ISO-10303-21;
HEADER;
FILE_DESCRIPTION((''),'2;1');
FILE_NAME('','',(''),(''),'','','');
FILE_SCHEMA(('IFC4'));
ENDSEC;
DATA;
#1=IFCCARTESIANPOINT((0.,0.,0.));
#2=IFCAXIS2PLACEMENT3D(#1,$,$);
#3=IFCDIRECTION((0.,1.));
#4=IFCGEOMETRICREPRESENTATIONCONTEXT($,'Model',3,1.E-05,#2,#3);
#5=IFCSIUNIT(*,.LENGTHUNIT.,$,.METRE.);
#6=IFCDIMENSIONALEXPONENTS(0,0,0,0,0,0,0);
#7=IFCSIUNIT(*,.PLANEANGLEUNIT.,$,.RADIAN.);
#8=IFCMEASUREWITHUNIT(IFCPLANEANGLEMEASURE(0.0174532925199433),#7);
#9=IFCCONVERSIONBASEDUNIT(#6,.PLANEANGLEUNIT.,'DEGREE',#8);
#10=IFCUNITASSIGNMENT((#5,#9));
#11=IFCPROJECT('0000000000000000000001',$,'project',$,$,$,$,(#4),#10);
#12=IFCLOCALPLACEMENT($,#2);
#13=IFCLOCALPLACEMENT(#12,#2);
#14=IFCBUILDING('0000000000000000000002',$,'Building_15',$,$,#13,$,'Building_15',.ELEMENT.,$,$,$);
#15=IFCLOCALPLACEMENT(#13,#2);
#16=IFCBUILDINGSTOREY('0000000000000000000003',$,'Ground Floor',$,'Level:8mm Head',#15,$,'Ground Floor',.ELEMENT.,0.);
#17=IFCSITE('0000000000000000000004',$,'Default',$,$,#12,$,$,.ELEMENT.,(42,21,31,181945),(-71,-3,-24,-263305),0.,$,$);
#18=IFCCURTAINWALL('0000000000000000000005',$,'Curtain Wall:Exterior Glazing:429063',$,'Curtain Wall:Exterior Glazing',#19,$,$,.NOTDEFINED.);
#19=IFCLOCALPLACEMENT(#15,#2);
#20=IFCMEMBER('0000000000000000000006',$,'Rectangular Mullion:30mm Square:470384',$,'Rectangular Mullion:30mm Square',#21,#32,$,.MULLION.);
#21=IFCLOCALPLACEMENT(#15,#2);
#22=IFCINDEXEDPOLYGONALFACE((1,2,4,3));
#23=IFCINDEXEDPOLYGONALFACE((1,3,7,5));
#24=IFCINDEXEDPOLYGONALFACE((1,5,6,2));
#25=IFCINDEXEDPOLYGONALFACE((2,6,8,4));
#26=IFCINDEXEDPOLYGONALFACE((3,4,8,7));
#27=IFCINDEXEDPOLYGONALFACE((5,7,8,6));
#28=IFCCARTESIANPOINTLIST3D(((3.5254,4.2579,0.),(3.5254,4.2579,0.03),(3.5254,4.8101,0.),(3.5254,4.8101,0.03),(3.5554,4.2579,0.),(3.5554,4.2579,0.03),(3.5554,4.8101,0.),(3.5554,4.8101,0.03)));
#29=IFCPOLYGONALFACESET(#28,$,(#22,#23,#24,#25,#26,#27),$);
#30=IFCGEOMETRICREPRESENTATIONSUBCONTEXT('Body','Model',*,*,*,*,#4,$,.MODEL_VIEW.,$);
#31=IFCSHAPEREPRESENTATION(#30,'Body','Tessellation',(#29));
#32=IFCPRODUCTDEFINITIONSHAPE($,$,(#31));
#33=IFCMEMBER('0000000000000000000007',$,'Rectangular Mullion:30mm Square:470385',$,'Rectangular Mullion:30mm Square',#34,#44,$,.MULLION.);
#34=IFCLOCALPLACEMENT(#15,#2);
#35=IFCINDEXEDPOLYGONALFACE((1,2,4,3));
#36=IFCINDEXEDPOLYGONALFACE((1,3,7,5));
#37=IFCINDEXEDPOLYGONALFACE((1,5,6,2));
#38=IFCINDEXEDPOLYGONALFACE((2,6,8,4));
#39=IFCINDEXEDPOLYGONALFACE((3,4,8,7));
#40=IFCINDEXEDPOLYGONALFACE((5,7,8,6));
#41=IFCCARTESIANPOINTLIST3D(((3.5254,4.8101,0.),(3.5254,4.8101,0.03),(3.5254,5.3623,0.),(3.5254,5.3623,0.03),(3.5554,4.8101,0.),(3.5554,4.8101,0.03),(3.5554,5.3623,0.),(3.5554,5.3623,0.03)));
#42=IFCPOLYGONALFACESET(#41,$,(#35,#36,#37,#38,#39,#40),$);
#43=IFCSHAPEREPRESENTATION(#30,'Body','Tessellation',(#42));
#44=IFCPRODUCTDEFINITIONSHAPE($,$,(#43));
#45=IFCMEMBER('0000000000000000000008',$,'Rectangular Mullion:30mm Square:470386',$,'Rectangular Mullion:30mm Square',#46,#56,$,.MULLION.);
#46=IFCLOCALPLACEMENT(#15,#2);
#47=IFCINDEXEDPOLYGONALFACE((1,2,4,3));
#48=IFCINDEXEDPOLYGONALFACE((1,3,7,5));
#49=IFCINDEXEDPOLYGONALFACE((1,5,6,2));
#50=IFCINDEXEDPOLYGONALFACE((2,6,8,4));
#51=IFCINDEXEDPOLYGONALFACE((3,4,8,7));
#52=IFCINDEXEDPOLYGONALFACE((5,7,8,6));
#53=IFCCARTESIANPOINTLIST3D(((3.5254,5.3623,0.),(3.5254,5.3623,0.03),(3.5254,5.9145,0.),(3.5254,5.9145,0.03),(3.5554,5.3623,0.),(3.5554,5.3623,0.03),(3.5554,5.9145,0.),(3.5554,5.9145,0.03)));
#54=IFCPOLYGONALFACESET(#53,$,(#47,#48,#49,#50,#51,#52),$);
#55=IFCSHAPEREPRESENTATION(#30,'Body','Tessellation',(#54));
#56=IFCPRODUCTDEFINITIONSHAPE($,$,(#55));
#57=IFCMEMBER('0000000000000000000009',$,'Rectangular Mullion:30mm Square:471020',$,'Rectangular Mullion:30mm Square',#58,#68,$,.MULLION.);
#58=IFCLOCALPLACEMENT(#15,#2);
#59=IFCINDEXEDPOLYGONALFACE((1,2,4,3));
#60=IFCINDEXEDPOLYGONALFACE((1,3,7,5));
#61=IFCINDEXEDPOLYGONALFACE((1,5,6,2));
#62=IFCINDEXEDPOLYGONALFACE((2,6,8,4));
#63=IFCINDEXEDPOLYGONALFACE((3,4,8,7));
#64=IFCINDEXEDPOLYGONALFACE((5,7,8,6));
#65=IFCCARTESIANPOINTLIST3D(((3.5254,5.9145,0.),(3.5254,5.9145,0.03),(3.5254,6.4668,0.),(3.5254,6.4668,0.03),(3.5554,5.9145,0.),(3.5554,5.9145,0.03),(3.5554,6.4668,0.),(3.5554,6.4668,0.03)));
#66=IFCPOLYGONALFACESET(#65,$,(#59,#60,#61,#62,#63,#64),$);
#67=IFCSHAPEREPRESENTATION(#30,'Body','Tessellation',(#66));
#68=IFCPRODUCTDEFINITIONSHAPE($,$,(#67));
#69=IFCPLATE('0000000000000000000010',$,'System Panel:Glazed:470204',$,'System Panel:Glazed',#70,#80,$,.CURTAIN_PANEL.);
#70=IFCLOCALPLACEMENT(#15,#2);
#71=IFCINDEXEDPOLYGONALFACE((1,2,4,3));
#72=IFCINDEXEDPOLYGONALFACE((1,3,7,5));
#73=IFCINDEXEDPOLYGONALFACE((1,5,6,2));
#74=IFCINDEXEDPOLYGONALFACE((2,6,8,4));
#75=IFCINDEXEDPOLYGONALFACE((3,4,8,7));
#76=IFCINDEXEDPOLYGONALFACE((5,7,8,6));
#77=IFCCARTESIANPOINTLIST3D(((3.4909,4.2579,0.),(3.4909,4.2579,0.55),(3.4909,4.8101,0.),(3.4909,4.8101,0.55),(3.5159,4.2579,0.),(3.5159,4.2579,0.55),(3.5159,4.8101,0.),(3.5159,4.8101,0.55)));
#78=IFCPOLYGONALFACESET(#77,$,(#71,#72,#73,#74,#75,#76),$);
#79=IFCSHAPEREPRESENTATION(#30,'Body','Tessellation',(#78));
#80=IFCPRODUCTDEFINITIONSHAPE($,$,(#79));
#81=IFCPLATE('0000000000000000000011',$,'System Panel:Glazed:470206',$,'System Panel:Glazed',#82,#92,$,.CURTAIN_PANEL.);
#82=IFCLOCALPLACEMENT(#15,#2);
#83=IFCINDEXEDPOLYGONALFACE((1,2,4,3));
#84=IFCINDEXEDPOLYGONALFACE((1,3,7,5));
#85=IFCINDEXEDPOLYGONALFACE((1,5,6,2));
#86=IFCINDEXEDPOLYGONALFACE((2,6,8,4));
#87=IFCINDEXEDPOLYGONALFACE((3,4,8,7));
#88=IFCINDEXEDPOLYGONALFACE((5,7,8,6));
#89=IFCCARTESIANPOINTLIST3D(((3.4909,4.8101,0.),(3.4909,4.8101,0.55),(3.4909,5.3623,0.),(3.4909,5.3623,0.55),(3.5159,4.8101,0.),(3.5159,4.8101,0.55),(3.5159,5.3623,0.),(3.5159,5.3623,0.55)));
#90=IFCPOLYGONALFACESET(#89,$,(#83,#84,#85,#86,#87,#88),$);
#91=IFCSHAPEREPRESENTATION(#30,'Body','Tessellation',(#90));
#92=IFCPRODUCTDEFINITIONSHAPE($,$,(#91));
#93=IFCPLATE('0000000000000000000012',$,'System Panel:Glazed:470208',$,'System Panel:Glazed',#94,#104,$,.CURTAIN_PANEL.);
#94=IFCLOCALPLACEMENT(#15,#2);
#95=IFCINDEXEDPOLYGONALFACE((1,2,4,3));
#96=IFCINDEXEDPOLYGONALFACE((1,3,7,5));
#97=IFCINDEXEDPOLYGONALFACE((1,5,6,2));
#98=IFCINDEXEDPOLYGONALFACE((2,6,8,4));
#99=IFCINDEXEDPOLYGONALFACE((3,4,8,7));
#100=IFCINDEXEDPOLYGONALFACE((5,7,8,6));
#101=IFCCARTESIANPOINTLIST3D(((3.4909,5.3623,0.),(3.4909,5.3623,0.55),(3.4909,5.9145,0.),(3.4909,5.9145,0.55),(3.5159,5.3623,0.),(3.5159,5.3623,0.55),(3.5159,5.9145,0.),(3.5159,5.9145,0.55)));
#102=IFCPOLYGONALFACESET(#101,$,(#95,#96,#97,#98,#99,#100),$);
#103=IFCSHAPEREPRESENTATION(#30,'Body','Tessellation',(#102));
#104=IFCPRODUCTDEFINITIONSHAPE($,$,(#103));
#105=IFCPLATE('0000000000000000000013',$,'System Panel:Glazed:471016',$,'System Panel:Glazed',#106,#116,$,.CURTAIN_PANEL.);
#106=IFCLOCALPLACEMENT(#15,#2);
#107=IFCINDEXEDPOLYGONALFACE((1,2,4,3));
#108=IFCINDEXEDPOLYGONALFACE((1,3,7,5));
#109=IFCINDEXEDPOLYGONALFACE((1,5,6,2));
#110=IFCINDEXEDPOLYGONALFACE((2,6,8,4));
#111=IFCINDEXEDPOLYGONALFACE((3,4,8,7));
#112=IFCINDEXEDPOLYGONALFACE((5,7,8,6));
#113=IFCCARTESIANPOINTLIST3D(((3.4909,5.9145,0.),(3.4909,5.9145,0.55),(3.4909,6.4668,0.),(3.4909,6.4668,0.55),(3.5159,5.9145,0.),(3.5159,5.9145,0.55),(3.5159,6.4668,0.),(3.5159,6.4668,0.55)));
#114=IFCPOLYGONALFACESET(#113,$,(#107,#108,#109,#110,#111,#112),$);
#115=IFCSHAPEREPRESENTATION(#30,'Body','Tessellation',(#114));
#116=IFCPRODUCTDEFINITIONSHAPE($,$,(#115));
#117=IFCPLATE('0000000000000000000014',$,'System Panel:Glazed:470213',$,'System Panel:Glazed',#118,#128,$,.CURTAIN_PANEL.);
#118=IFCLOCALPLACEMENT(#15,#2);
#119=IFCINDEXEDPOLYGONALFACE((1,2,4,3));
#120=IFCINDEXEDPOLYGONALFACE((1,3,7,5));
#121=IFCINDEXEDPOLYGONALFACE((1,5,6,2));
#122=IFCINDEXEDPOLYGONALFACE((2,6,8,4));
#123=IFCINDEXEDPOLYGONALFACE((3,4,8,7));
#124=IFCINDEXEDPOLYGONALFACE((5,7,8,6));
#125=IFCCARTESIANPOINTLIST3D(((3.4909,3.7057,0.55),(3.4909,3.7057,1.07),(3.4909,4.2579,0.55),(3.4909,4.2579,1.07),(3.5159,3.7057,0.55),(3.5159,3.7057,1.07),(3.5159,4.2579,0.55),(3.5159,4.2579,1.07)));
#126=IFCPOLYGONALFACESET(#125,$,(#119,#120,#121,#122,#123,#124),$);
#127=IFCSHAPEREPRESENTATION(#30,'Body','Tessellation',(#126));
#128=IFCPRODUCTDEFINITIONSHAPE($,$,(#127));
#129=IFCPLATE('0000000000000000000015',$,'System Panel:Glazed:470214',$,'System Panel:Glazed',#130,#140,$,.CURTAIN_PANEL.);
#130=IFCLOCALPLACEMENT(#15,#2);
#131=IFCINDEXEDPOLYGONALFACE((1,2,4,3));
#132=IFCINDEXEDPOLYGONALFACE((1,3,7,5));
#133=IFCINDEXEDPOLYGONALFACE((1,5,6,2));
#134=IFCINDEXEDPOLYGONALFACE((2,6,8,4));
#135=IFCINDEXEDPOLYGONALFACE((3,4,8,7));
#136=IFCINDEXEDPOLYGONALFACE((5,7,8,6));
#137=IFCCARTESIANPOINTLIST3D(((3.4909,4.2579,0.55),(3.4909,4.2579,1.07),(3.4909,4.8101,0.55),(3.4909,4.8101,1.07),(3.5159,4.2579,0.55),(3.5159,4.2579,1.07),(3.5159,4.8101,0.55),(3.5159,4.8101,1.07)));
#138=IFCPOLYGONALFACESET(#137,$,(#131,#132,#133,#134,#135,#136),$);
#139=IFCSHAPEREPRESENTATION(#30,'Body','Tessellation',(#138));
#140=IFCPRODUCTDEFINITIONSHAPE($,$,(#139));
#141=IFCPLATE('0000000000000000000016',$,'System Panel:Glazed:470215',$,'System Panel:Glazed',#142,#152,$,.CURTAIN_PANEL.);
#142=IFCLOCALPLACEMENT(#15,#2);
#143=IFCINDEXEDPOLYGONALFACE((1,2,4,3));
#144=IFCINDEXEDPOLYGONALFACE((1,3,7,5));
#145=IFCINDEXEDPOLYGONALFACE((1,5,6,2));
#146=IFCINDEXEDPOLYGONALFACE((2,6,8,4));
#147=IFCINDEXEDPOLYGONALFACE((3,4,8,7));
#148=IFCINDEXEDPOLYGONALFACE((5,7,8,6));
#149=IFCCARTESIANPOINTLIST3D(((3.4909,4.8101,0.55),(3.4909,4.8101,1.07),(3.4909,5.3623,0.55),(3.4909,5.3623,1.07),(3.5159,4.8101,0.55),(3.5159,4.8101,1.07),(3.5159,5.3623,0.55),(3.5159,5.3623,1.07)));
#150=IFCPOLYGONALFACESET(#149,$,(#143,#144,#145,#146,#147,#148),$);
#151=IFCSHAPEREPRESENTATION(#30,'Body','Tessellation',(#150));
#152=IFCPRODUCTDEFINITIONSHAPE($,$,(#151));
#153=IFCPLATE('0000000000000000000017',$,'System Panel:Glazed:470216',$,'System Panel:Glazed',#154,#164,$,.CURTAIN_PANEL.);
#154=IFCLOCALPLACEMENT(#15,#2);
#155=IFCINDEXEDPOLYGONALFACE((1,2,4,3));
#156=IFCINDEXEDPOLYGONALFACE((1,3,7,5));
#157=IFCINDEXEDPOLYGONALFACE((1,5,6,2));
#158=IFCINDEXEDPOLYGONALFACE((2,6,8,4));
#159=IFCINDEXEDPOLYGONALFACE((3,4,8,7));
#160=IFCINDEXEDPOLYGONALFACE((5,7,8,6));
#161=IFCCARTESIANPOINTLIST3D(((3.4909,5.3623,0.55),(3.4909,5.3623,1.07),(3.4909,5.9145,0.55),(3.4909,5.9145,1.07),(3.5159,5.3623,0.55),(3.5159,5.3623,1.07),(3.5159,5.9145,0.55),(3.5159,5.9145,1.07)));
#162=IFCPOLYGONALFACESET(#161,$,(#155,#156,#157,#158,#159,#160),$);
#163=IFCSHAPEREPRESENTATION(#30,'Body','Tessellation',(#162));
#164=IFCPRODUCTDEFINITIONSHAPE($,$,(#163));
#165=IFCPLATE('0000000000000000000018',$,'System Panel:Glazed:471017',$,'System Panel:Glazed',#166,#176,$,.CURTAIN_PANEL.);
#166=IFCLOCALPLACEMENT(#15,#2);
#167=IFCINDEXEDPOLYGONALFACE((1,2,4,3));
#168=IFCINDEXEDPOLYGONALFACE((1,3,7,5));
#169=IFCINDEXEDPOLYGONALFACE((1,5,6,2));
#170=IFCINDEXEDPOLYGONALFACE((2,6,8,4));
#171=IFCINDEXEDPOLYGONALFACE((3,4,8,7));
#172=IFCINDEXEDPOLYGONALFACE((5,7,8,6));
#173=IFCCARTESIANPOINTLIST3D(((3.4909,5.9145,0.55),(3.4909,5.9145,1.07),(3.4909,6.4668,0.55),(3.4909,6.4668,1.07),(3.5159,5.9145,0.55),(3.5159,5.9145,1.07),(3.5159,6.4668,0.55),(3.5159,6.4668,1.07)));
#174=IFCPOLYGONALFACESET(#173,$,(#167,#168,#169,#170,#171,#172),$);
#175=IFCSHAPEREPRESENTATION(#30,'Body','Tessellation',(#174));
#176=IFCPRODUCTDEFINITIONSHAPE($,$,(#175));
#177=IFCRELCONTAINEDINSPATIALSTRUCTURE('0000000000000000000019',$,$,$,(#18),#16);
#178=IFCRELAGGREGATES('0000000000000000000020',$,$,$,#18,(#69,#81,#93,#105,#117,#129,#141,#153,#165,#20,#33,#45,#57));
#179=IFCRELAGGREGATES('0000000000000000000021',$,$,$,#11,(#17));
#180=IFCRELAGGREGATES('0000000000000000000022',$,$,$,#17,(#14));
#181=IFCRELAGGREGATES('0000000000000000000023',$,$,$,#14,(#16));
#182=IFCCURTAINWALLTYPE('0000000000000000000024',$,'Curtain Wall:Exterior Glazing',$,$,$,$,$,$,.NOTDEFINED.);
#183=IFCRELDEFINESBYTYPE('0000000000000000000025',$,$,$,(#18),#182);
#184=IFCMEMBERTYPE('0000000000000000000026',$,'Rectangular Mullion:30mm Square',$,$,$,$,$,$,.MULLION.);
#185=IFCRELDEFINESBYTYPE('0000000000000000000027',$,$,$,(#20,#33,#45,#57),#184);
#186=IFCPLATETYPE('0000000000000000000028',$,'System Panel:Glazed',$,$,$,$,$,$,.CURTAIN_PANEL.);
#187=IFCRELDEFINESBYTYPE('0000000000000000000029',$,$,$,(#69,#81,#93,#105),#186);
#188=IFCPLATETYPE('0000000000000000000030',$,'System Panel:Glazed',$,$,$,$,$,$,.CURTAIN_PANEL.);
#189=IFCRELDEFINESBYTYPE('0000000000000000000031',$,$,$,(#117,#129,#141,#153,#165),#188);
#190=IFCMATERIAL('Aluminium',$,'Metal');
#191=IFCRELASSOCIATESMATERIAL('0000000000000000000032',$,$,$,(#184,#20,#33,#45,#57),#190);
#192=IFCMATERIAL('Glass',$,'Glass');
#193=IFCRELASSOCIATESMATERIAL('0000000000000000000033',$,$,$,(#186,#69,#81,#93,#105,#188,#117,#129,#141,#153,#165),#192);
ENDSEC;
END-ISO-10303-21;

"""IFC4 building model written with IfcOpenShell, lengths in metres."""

from ifc_helpers import new_model, entity, si_unit, converted_unit, direction, frame, origin, place, context, subcontext, project, spatial, indexed_curve, outline, extrude, source, transform, mapped, material, type_object, type_shapes, element, aggregate, save


model = new_model("IFC4")

# Units and contexts
model_context = context("Model", 3, precision=1e-05, world=origin(), true_north=direction((0.0, 1.0)))
body_context = subcontext(model_context, "Body", "Model", "MODEL_VIEW")
ifc_project = project(units=[si_unit("LENGTHUNIT", "METRE"), converted_unit("PLANEANGLEUNIT", "DEGREE", entity("IfcPlaneAngleMeasure", 0.0174532925199433), si_unit("PLANEANGLEUNIT", "RADIAN"), dimensions=[0, 0, 0, 0, 0, 0, 0])], contexts=[model_context])

# Site, building, storey
site_placement = place(None, origin())
site = spatial("IfcSite", under=ifc_project, at=site_placement, Name="Default", CompositionType="ELEMENT", RefLatitude=(42, 21, 31, 181945), RefLongitude=(-71, -3, -24, -263305), RefElevation=0.0)
building_placement = place(site_placement, origin())
building = spatial("IfcBuilding", under=site, at=building_placement, Name="Building_15", LongName="Building_15", CompositionType="ELEMENT")
storey_placement = place(building_placement, origin())
storey = spatial("IfcBuildingStorey", under=building, at=storey_placement, Name="Ground Floor", ObjectType="Level:8mm Head", LongName="Ground Floor", CompositionType="ELEMENT", Elevation=0.0)

# Curtain wall, members, plates
curtain_wall_type = type_object("IfcCurtainWallType", Name="Curtain Wall:Exterior Glazing", PredefinedType="NOTDEFINED")
curtain_wall_placement = place(storey_placement, origin())
curtain_wall = element("IfcCurtainWall", 1, at=curtain_wall_placement, inside=storey, type_object=curtain_wall_type, Name="Curtain Wall:Exterior Glazing:429063", ObjectType="Curtain Wall:Exterior Glazing", PredefinedType="NOTDEFINED")
ifc_material_1 = material(Name="Aluminium", Category="Metal")
member_type = type_object("IfcMemberType", Name="Rectangular Mullion:30mm Square", PredefinedType="MULLION", material=ifc_material_1)
shared_shape_1 = source(origin(), body_context, "Body", "SweptSolid", [
    extrude(outline(indexed_curve([(-0.015, -0.015), (0.015, -0.015), (0.015, 0.015), (-0.015, 0.015), (-0.015, -0.015)], self_intersect=False)), frame((-0.015, 0.0, -0.5522), z_axis=(0.0, 0.0, 1.0), x_axis=(-1.0, 0.0, 0.0)), (0.0, 0.0, 1.0), 0.5522),
])
type_shapes(member_type, [shared_shape_1])
member_1_placement = place(curtain_wall_placement, frame((3.5404, 4.2579, 0.0), z_axis=(0.0, -1.0, 0.0), x_axis=(0.0, 0.0, -1.0)))
member_1 = element("IfcMember", 2, at=member_1_placement, type_object=member_type, material=ifc_material_1, Name="Rectangular Mullion:30mm Square:470384", ObjectType="Rectangular Mullion:30mm Square", PredefinedType="MULLION", context=body_context, shape_type="MappedRepresentation", body=[
    mapped(shared_shape_1, transform((0.0, 0.0, 0.0), scale=1.0)),
])
member_2_placement = place(curtain_wall_placement, frame((3.5404, 4.8101, 0.0), z_axis=(0.0, -1.0, 0.0), x_axis=(0.0, 0.0, -1.0)))
member_2 = element("IfcMember", 3, at=member_2_placement, type_object=member_type, material=ifc_material_1, Name="Rectangular Mullion:30mm Square:470385", ObjectType="Rectangular Mullion:30mm Square", PredefinedType="MULLION", context=body_context, shape_type="MappedRepresentation", body=[
    mapped(shared_shape_1, transform((0.0, 0.0, 0.0), scale=1.0)),
])
member_3_placement = place(curtain_wall_placement, frame((3.5404, 5.3623, 0.0), z_axis=(0.0, -1.0, 0.0), x_axis=(0.0, 0.0, -1.0)))
member_3 = element("IfcMember", 4, at=member_3_placement, type_object=member_type, material=ifc_material_1, Name="Rectangular Mullion:30mm Square:470386", ObjectType="Rectangular Mullion:30mm Square", PredefinedType="MULLION", context=body_context, shape_type="MappedRepresentation", body=[
    mapped(shared_shape_1, transform((0.0, 0.0, 0.0), scale=1.0)),
])
member_4_placement = place(curtain_wall_placement, frame((3.5404, 5.9145, 0.0), z_axis=(0.0, -1.0, 0.0), x_axis=(0.0, 0.0, -1.0)))
member_4 = element("IfcMember", 5, at=member_4_placement, type_object=member_type, material=ifc_material_1, Name="Rectangular Mullion:30mm Square:471020", ObjectType="Rectangular Mullion:30mm Square", PredefinedType="MULLION", context=body_context, shape_type="MappedRepresentation", body=[
    mapped(shared_shape_1, transform((0.0, 0.0, 0.0), scale=1.0)),
])
ifc_material_2 = material(Name="Glass", Category="Glass")
plate_type_1 = type_object("IfcPlateType", Name="System Panel:Glazed", PredefinedType="CURTAIN_PANEL", material=ifc_material_2)
shared_shape_2 = source(origin(), body_context, "Body", "SweptSolid", [
    extrude(outline(indexed_curve([(-0.0125, -0.2761), (0.0125, -0.2761), (0.0125, 0.2761), (-0.0125, 0.2761), (-0.0125, -0.2761)], self_intersect=False)), frame((0.0, 0.037, 0.0), z_axis=(0.0, 0.0, 1.0), x_axis=(0.0, 1.0, 0.0)), (0.0, 0.0, 1.0), 0.55),
])
type_shapes(plate_type_1, [shared_shape_2])
plate_1_placement = place(curtain_wall_placement, frame((3.5404, 4.534, 0.0), z_axis=(0.0, 0.0, 1.0), x_axis=(0.0, 1.0, 0.0)))
plate_1 = element("IfcPlate", 6, at=plate_1_placement, type_object=plate_type_1, material=ifc_material_2, Name="System Panel:Glazed:470204", ObjectType="System Panel:Glazed", PredefinedType="CURTAIN_PANEL", context=body_context, shape_type="MappedRepresentation", body=[
    mapped(shared_shape_2, transform((0.0, 0.0, 0.0), scale=1.0)),
])
plate_2_placement = place(curtain_wall_placement, frame((3.5404, 5.0862, 0.0), z_axis=(0.0, 0.0, 1.0), x_axis=(0.0, 1.0, 0.0)))
plate_2 = element("IfcPlate", 7, at=plate_2_placement, type_object=plate_type_1, material=ifc_material_2, Name="System Panel:Glazed:470206", ObjectType="System Panel:Glazed", PredefinedType="CURTAIN_PANEL", context=body_context, shape_type="MappedRepresentation", body=[
    mapped(shared_shape_2, transform((0.0, 0.0, 0.0), scale=1.0)),
])
plate_3_placement = place(curtain_wall_placement, frame((3.5404, 5.6384, 0.0), z_axis=(0.0, 0.0, 1.0), x_axis=(0.0, 1.0, 0.0)))
plate_3 = element("IfcPlate", 8, at=plate_3_placement, type_object=plate_type_1, material=ifc_material_2, Name="System Panel:Glazed:470208", ObjectType="System Panel:Glazed", PredefinedType="CURTAIN_PANEL", context=body_context, shape_type="MappedRepresentation", body=[
    mapped(shared_shape_2, transform((0.0, 0.0, 0.0), scale=1.0)),
])
plate_4_placement = place(curtain_wall_placement, frame((3.5404, 6.1907, 0.0), z_axis=(0.0, 0.0, 1.0), x_axis=(0.0, 1.0, 0.0)))
plate_4 = element("IfcPlate", 9, at=plate_4_placement, type_object=plate_type_1, material=ifc_material_2, Name="System Panel:Glazed:471016", ObjectType="System Panel:Glazed", PredefinedType="CURTAIN_PANEL", context=body_context, shape_type="MappedRepresentation", body=[
    mapped(shared_shape_2, transform((0.0, 0.0, 0.0), scale=1.0)),
])
plate_type_2 = type_object("IfcPlateType", Name="System Panel:Glazed", PredefinedType="CURTAIN_PANEL", material=ifc_material_2)
shared_shape_3 = source(origin(), body_context, "Body", "SweptSolid", [
    extrude(outline(indexed_curve([(-0.0125, -0.2761), (0.0125, -0.2761), (0.0125, 0.2761), (-0.0125, 0.2761), (-0.0125, -0.2761)], self_intersect=False)), frame((0.0, 0.037, 0.0), z_axis=(0.0, 0.0, 1.0), x_axis=(0.0, 1.0, 0.0)), (0.0, 0.0, 1.0), 0.52),
])
type_shapes(plate_type_2, [shared_shape_3])
plate_5_placement = place(curtain_wall_placement, frame((3.5404, 3.9818, 0.55), z_axis=(0.0, 0.0, 1.0), x_axis=(0.0, 1.0, 0.0)))
plate_5 = element("IfcPlate", 10, at=plate_5_placement, type_object=plate_type_2, material=ifc_material_2, Name="System Panel:Glazed:470213", ObjectType="System Panel:Glazed", PredefinedType="CURTAIN_PANEL", context=body_context, shape_type="MappedRepresentation", body=[
    mapped(shared_shape_3, transform((0.0, 0.0, 0.0), scale=1.0)),
])
plate_6_placement = place(curtain_wall_placement, frame((3.5404, 4.534, 0.55), z_axis=(0.0, 0.0, 1.0), x_axis=(0.0, 1.0, 0.0)))
plate_6 = element("IfcPlate", 11, at=plate_6_placement, type_object=plate_type_2, material=ifc_material_2, Name="System Panel:Glazed:470214", ObjectType="System Panel:Glazed", PredefinedType="CURTAIN_PANEL", context=body_context, shape_type="MappedRepresentation", body=[
    mapped(shared_shape_3, transform((0.0, 0.0, 0.0), scale=1.0)),
])
plate_7_placement = place(curtain_wall_placement, frame((3.5404, 5.0862, 0.55), z_axis=(0.0, 0.0, 1.0), x_axis=(0.0, 1.0, 0.0)))
plate_7 = element("IfcPlate", 12, at=plate_7_placement, type_object=plate_type_2, material=ifc_material_2, Name="System Panel:Glazed:470215", ObjectType="System Panel:Glazed", PredefinedType="CURTAIN_PANEL", context=body_context, shape_type="MappedRepresentation", body=[
    mapped(shared_shape_3, transform((0.0, 0.0, 0.0), scale=1.0)),
])
plate_8_placement = place(curtain_wall_placement, frame((3.5404, 5.6384, 0.55), z_axis=(0.0, 0.0, 1.0), x_axis=(0.0, 1.0, 0.0)))
plate_8 = element("IfcPlate", 13, at=plate_8_placement, type_object=plate_type_2, material=ifc_material_2, Name="System Panel:Glazed:470216", ObjectType="System Panel:Glazed", PredefinedType="CURTAIN_PANEL", context=body_context, shape_type="MappedRepresentation", body=[
    mapped(shared_shape_3, transform((0.0, 0.0, 0.0), scale=1.0)),
])
plate_9_placement = place(curtain_wall_placement, frame((3.5404, 6.1907, 0.55), z_axis=(0.0, 0.0, 1.0), x_axis=(0.0, 1.0, 0.0)))
plate_9 = element("IfcPlate", 14, at=plate_9_placement, type_object=plate_type_2, material=ifc_material_2, Name="System Panel:Glazed:471017", ObjectType="System Panel:Glazed", PredefinedType="CURTAIN_PANEL", context=body_context, shape_type="MappedRepresentation", body=[
    mapped(shared_shape_3, transform((0.0, 0.0, 0.0), scale=1.0)),
])
aggregate(curtain_wall, [plate_1, plate_2, plate_3, plate_4, plate_5, plate_6, plate_7, plate_8, plate_9, member_1, member_2, member_3, member_4])

save(model, "model.ifc")
